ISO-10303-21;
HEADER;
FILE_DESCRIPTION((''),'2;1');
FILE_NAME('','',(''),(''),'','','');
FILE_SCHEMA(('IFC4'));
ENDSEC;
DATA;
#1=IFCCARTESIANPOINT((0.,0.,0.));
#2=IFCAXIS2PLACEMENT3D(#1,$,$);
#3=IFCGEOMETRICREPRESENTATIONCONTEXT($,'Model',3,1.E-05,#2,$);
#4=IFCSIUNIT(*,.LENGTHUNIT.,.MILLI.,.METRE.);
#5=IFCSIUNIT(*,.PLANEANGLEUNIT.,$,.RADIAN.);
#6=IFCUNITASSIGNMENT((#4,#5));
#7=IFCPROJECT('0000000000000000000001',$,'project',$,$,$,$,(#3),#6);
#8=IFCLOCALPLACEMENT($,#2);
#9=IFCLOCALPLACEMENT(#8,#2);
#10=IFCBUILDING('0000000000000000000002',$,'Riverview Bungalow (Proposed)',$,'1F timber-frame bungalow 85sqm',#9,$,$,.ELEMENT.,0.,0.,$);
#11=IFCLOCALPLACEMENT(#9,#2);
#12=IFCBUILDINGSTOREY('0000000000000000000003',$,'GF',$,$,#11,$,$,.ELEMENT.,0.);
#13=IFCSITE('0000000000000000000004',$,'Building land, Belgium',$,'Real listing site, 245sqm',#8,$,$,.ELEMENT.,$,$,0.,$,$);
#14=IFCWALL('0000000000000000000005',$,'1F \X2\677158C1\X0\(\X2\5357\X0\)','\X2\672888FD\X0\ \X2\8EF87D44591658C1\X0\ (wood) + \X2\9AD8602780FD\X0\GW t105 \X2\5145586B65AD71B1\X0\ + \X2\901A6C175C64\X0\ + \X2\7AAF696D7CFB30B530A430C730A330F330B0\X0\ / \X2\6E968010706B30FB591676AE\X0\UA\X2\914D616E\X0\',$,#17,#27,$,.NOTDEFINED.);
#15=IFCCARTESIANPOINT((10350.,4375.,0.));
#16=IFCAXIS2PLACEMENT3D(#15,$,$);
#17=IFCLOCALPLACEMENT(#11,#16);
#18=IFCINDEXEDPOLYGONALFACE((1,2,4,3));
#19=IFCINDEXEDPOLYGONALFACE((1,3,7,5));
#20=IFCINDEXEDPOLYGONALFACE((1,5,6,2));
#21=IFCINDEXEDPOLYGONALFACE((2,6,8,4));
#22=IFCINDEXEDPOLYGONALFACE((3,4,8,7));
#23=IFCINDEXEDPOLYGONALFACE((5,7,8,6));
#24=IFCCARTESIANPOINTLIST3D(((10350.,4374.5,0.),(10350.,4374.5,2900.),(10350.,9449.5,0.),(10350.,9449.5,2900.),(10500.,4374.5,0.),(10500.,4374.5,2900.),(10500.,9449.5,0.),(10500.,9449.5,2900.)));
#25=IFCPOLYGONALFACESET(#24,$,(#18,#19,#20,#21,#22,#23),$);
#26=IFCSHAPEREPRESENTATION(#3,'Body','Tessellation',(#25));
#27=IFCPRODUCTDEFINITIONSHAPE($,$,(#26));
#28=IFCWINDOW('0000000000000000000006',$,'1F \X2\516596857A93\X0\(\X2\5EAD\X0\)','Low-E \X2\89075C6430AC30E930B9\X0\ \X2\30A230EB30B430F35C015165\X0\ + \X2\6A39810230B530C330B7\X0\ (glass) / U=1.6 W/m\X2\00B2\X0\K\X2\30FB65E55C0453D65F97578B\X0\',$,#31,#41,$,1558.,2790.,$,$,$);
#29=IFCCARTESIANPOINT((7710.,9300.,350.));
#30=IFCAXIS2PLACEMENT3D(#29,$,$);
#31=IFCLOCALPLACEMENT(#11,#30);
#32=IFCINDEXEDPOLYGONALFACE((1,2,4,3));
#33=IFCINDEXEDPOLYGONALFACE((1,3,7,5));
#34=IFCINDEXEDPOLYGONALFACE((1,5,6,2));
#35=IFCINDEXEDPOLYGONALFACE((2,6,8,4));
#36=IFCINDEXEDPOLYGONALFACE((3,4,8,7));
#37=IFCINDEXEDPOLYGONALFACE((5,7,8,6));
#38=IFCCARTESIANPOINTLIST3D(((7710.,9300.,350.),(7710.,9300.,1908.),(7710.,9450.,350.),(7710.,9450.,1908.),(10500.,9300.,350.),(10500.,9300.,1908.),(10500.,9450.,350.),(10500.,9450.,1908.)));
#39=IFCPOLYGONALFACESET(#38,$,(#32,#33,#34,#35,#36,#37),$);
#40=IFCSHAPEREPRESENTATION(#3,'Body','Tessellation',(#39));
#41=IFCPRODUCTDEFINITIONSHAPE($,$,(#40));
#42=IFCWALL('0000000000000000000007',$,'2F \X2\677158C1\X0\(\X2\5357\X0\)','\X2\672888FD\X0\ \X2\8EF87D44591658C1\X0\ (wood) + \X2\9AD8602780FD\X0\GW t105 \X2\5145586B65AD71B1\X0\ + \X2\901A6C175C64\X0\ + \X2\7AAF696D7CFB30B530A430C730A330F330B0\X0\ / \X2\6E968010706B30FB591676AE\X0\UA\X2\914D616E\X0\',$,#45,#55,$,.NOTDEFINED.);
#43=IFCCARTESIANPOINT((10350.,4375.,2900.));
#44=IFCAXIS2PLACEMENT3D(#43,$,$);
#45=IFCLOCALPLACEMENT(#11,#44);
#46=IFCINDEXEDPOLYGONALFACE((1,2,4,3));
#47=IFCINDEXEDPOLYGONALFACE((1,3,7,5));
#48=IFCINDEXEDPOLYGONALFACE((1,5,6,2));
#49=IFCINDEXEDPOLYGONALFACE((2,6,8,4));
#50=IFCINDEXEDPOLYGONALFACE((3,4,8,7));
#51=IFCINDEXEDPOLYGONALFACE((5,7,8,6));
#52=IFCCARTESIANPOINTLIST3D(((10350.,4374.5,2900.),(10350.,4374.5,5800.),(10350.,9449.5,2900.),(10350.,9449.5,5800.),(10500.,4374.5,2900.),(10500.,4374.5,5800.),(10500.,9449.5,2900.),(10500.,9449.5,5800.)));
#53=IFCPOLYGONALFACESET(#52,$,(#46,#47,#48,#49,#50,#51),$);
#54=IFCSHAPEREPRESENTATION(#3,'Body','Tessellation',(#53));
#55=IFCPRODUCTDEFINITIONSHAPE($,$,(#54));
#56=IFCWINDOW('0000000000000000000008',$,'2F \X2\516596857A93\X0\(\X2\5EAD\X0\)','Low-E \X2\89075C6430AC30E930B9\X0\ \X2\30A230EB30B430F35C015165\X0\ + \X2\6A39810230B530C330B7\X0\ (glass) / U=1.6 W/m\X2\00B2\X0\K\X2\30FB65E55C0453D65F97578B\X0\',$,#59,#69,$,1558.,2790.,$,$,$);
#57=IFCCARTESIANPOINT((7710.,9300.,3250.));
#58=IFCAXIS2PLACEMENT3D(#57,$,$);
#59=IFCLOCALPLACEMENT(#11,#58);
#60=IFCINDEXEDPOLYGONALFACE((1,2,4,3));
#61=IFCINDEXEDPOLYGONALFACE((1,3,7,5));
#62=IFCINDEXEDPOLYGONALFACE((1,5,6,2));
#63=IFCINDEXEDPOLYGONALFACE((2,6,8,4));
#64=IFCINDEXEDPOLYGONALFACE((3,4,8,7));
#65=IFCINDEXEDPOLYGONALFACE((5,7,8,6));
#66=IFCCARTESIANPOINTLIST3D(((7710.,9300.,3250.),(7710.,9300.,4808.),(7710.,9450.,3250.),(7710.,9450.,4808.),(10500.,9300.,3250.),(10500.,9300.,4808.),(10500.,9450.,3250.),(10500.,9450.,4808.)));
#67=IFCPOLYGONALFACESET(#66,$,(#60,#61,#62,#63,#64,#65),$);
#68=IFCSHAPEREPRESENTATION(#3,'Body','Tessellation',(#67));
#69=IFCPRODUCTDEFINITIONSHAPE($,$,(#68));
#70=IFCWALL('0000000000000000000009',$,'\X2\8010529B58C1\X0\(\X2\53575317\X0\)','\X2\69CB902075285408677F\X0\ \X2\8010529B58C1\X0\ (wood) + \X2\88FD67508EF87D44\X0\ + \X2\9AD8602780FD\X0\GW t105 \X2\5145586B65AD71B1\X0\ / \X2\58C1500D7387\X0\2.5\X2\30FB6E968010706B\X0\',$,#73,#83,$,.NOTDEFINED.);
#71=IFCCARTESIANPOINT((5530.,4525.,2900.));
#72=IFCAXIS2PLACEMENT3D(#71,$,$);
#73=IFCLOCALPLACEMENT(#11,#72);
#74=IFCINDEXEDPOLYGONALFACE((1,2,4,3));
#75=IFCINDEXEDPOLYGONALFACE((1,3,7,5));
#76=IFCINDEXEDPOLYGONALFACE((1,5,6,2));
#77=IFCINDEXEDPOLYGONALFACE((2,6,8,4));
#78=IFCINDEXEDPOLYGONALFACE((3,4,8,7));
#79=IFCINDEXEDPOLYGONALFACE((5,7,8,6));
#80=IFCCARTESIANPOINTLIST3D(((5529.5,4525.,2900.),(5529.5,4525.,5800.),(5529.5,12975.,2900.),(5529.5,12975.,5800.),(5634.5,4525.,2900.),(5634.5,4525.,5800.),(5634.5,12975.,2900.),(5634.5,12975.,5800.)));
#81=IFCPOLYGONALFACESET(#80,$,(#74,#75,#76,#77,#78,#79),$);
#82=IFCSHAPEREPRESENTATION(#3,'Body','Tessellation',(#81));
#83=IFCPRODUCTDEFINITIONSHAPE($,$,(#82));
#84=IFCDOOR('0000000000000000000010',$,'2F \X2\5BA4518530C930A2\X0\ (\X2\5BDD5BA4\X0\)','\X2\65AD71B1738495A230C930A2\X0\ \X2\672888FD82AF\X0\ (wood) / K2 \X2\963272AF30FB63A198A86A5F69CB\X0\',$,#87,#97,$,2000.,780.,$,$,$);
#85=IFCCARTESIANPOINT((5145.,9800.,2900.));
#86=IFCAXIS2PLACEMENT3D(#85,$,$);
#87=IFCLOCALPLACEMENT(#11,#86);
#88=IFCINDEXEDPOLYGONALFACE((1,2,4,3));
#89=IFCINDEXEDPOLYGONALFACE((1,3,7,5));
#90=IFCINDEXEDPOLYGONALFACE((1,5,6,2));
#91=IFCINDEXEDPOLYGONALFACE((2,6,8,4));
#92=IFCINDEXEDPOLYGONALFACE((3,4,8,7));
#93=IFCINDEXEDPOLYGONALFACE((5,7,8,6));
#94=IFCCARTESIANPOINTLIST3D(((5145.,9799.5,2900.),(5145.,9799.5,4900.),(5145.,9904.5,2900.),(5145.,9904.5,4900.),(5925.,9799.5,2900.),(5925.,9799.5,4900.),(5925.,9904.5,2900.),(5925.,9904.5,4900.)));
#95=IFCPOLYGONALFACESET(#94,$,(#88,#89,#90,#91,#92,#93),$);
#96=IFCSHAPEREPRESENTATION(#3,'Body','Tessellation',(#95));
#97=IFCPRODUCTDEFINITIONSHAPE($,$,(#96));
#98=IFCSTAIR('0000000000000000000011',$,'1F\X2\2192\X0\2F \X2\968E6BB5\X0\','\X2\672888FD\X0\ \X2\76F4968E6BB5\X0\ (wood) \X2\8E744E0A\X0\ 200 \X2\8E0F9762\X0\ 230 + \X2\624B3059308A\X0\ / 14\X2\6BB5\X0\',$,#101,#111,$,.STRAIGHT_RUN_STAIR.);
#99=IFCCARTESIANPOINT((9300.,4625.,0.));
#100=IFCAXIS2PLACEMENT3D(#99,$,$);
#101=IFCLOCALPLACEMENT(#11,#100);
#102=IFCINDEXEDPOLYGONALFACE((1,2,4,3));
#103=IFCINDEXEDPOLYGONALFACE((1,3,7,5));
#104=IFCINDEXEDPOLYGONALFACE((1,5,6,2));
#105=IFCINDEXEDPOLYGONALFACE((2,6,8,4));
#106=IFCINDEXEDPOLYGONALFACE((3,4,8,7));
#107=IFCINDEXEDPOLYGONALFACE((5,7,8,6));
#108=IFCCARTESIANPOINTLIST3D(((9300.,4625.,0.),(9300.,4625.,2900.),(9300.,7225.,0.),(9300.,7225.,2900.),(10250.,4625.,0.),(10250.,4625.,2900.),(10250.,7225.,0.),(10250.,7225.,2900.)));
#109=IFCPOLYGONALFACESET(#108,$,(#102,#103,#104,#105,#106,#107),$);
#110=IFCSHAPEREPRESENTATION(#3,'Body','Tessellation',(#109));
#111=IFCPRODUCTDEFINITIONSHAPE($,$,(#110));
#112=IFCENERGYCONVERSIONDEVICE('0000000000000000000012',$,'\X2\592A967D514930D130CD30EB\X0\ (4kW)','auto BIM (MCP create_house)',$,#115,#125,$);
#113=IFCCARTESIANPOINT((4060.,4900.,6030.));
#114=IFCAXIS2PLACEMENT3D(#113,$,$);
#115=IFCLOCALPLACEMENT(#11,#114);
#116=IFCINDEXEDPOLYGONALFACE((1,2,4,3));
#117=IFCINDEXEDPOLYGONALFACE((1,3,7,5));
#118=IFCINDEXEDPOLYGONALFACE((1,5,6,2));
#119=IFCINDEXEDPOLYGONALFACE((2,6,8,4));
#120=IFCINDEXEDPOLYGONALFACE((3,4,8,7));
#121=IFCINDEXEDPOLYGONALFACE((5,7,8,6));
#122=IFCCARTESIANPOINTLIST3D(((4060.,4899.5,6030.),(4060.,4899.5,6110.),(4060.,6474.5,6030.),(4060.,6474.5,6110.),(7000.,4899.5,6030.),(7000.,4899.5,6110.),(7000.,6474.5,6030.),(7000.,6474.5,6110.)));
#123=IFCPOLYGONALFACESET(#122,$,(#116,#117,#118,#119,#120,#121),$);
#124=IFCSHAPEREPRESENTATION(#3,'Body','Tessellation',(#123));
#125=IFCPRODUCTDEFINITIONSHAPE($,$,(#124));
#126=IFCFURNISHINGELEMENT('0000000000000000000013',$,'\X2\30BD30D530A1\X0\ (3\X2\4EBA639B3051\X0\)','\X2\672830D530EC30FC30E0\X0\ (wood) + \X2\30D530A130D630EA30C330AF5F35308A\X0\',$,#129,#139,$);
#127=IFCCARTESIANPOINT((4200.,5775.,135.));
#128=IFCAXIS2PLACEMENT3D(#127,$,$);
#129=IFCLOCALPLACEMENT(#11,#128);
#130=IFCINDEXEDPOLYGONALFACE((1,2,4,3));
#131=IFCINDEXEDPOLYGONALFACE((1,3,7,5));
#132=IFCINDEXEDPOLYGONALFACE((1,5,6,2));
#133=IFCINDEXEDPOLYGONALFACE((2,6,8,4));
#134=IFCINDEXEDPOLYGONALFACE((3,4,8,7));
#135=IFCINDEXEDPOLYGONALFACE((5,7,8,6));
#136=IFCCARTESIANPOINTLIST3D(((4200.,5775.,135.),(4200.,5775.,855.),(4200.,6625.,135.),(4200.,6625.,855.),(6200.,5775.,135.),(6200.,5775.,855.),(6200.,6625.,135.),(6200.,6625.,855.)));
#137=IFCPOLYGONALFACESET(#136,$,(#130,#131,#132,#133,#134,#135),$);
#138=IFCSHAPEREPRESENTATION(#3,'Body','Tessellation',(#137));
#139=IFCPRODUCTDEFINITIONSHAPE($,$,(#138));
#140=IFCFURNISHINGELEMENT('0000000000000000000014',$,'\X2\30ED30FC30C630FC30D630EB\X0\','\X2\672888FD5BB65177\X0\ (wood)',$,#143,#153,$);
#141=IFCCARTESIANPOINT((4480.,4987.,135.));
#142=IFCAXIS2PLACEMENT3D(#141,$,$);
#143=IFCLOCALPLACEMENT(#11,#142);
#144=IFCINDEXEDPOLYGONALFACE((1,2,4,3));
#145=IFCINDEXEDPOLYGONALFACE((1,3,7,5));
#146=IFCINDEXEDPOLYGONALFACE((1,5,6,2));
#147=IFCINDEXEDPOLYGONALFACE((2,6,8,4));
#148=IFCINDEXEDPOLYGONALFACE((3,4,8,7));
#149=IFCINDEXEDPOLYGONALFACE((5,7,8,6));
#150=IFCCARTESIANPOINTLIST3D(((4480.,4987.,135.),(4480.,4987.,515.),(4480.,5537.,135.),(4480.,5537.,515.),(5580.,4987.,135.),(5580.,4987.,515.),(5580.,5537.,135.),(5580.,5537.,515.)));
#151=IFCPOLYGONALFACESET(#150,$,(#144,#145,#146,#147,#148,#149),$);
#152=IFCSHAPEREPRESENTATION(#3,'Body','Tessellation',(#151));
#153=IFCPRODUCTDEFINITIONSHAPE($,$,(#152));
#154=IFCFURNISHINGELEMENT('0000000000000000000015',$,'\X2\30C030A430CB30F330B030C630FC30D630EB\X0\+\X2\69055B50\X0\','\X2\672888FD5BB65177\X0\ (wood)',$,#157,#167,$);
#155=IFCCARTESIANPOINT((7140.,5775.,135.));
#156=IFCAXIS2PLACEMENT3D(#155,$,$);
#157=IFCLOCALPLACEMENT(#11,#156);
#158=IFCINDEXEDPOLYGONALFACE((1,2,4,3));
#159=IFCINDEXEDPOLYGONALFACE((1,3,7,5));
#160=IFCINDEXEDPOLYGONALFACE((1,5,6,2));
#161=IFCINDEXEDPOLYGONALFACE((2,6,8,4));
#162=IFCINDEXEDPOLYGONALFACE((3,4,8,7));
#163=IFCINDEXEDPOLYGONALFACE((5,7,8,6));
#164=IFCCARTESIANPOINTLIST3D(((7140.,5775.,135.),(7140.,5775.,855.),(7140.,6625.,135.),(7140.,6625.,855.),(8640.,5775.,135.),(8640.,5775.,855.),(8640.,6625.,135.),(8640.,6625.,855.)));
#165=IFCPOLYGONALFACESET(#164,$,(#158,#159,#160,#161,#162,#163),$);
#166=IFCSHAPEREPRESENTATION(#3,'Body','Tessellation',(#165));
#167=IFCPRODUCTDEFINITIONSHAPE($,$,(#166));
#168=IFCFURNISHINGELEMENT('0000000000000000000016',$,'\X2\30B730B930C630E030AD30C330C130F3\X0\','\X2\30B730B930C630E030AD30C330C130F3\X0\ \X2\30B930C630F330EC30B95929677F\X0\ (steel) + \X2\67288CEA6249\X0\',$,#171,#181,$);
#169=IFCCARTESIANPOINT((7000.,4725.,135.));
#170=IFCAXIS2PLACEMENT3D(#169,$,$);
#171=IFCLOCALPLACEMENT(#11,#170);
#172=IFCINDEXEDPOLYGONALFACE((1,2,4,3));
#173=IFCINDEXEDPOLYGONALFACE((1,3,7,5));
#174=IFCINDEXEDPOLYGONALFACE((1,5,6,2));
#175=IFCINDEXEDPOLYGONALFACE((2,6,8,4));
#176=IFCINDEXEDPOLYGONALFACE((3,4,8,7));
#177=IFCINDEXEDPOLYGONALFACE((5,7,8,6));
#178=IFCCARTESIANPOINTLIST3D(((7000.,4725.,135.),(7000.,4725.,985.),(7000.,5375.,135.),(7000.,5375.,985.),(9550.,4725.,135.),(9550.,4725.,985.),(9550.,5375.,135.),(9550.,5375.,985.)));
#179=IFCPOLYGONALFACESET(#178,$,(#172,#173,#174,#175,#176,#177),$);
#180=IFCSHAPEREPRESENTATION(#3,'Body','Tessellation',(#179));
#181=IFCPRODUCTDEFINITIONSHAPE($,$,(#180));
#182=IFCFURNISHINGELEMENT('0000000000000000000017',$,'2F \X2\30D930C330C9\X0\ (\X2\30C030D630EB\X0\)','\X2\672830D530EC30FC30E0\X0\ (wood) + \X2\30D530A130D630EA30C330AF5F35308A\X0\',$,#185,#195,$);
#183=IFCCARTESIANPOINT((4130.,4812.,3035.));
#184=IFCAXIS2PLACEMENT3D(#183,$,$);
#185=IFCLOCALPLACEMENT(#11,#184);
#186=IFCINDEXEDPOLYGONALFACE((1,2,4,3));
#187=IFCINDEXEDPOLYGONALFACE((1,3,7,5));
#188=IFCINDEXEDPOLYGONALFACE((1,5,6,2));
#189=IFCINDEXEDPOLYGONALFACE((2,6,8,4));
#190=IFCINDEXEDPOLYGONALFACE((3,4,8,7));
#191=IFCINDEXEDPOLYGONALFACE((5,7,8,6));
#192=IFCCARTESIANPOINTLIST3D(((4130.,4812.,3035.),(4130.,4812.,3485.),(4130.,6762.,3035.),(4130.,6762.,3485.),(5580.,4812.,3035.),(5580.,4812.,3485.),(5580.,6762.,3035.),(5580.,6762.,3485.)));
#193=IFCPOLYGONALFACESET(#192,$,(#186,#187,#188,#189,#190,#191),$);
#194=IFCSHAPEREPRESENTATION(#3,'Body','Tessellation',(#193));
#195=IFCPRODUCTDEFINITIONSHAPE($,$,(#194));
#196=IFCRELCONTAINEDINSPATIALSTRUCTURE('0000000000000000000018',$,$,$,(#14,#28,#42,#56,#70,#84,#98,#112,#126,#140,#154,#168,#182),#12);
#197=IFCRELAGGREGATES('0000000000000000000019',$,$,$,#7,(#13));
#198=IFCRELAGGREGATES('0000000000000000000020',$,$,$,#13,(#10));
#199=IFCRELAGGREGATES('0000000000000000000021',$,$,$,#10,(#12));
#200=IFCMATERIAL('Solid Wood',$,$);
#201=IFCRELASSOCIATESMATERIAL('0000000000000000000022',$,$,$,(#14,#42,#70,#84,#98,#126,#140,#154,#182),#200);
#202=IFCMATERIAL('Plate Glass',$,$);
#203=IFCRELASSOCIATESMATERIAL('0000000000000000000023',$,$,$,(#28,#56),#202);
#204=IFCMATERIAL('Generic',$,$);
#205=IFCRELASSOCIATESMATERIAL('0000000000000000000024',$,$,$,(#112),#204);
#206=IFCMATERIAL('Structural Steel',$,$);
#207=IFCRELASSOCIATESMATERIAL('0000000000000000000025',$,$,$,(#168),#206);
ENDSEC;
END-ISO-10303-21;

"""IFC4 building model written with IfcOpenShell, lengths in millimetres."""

from ifc_helpers import new_model, si_unit, frame, frame_2d, origin, place, context, project, spatial, rectangle, extrude, material, element, fill, save


model = new_model("IFC4")

# Units and contexts
model_context = context("Model", 3, precision=1e-05, world=origin())
ifc_project = project(units=[si_unit("LENGTHUNIT", "METRE", prefix="MILLI"), si_unit("PLANEANGLEUNIT", "RADIAN")], contexts=[model_context])

# Site, building, storey
site_placement = place(None, origin())
site = spatial("IfcSite", under=ifc_project, at=site_placement, Name="Building land, Belgium", ObjectType="Real listing site, 245sqm", CompositionType="ELEMENT", RefElevation=0.0)
building_placement = place(site_placement, origin())
building = spatial("IfcBuilding", under=site, at=building_placement, Name="Riverview Bungalow (Proposed)", ObjectType="1F timber-frame bungalow 85sqm", CompositionType="ELEMENT", ElevationOfRefHeight=0.0, ElevationOfTerrain=0.0)
storey_placement = place(building_placement, origin())
storey = spatial("IfcBuildingStorey", under=building, at=storey_placement, Name="GF", CompositionType="ELEMENT", Elevation=0.0)

# Wall, opening, window
ifc_material_1 = material(Name="Solid Wood")
wall_1_placement = place(storey_placement, frame((10350.0, 4375.0, 0.0)))
wall_1 = element("IfcWall", 1, at=wall_1_placement, inside=storey, material=ifc_material_1, Name="1F 東壁(南)", Description="木製 軸組外壁 (wood) + 高性能GW t105 充填断熱 + 通気層 + 窯業系サイディング / 準耐火・外皮UA配慮", PredefinedType="NOTDEFINED", context=model_context, shape_type="SweptSolid", body=[
    extrude(rectangle(XDim=150.0, YDim=5075.0, at=frame_2d((75.0, 2537.0))), frame((10350.0, 4375.0, 0.0)), (0.0, 0.0, 1.0), 2900.0),
])
opening_1_placement = place(storey_placement, frame((7710.0, 9300.0, 350.0)))
opening_1 = element("IfcOpeningElement", 2, at=opening_1_placement, cuts=wall_1, PredefinedType="NOTDEFINED", context=model_context, shape_type="SweptSolid", body=[
    extrude(rectangle(XDim=2790.0, YDim=150.0, at=frame_2d((1395.0, 75.0))), frame((7710.0, 9300.0, 350.0)), (0.0, 0.0, 1.0), 1558.0),
])
ifc_material_2 = material(Name="Plate Glass")
window_1_placement = place(storey_placement, frame((7710.0, 9300.0, 350.0)))
window_1 = element("IfcWindow", 3, at=window_1_placement, inside=storey, material=ifc_material_2, Name="1F 入隅窓(庭)", Description="Low-E 複層ガラス アルゴン封入 + 樹脂サッシ (glass) / U=1.6 W/m²K・日射取得型", OverallHeight=1558.0, OverallWidth=2790.0, context=model_context, shape_type="SweptSolid", body=[
    extrude(rectangle(XDim=2790.0, YDim=150.0, at=frame_2d((1395.0, 75.0))), frame((7710.0, 9300.0, 350.0)), (0.0, 0.0, 1.0), 1558.0),
])
fill(opening_1, window_1)

# Wall, opening, window
wall_2_placement = place(storey_placement, frame((10350.0, 4375.0, 2900.0)))
wall_2 = element("IfcWall", 4, at=wall_2_placement, inside=storey, material=ifc_material_1, Name="2F 東壁(南)", Description="木製 軸組外壁 (wood) + 高性能GW t105 充填断熱 + 通気層 + 窯業系サイディング / 準耐火・外皮UA配慮", PredefinedType="NOTDEFINED", context=model_context, shape_type="SweptSolid", body=[
    extrude(rectangle(XDim=150.0, YDim=5075.0, at=frame_2d((75.0, 2537.0))), frame((10350.0, 4375.0, 2900.0)), (0.0, 0.0, 1.0), 2900.0),
])
opening_2_placement = place(storey_placement, frame((7710.0, 9300.0, 3250.0)))
opening_2 = element("IfcOpeningElement", 5, at=opening_2_placement, cuts=wall_2, PredefinedType="NOTDEFINED", context=model_context, shape_type="SweptSolid", body=[
    extrude(rectangle(XDim=2790.0, YDim=150.0, at=frame_2d((1395.0, 75.0))), frame((7710.0, 9300.0, 3250.0)), (0.0, 0.0, 1.0), 1558.0),
])
window_2_placement = place(storey_placement, frame((7710.0, 9300.0, 3250.0)))
window_2 = element("IfcWindow", 6, at=window_2_placement, inside=storey, material=ifc_material_2, Name="2F 入隅窓(庭)", Description="Low-E 複層ガラス アルゴン封入 + 樹脂サッシ (glass) / U=1.6 W/m²K・日射取得型", OverallHeight=1558.0, OverallWidth=2790.0, context=model_context, shape_type="SweptSolid", body=[
    extrude(rectangle(XDim=2790.0, YDim=150.0, at=frame_2d((1395.0, 75.0))), frame((7710.0, 9300.0, 3250.0)), (0.0, 0.0, 1.0), 1558.0),
])
fill(opening_2, window_2)

# Wall, opening, door
wall_3_placement = place(storey_placement, frame((5530.0, 4525.0, 2900.0)))
wall_3 = element("IfcWall", 7, at=wall_3_placement, inside=storey, material=ifc_material_1, Name="耐力壁(南北)", Description="構造用合板 耐力壁 (wood) + 製材軸組 + 高性能GW t105 充填断熱 / 壁倍率2.5・準耐火", PredefinedType="NOTDEFINED", context=model_context, shape_type="SweptSolid", body=[
    extrude(rectangle(XDim=105.0, YDim=8450.0, at=frame_2d((52.0, 4225.0))), frame((5530.0, 4525.0, 2900.0)), (0.0, 0.0, 1.0), 2900.0),
])
opening_3_placement = place(storey_placement, frame((5145.0, 9800.0, 2900.0)))
opening_3 = element("IfcOpeningElement", 8, at=opening_3_placement, cuts=wall_3, PredefinedType="NOTDEFINED", context=model_context, shape_type="SweptSolid", body=[
    extrude(rectangle(XDim=780.0, YDim=105.0, at=frame_2d((390.0, 52.0))), frame((5145.0, 9800.0, 2900.0)), (0.0, 0.0, 1.0), 2000.0),
])
door_1_placement = place(storey_placement, frame((5145.0, 9800.0, 2900.0)))
door_1 = element("IfcDoor", 9, at=door_1_placement, inside=storey, material=ifc_material_1, Name="2F 室内ドア (寝室)", Description="断熱玄関ドア 木製芯 (wood) / K2 防犯・採風機構", OverallHeight=2000.0, OverallWidth=780.0, context=model_context, shape_type="SweptSolid", body=[
    extrude(rectangle(XDim=780.0, YDim=105.0, at=frame_2d((390.0, 52.0))), frame((5145.0, 9800.0, 2900.0)), (0.0, 0.0, 1.0), 2000.0),
])
fill(opening_3, door_1)

# Stair
stair_placement = place(storey_placement, frame((9300.0, 4625.0, 0.0)))
element("IfcStair", 10, at=stair_placement, inside=storey, material=ifc_material_1, Name="1F→2F 階段", Description="木製 直階段 (wood) 蹴上 200 踏面 230 + 手すり / 14段", PredefinedType="STRAIGHT_RUN_STAIR", context=model_context, shape_type="SweptSolid", body=[
    extrude(rectangle(XDim=950.0, YDim=2600.0, at=frame_2d((475.0, 1300.0))), frame((9300.0, 4625.0, 0.0)), (0.0, 0.0, 1.0), 2900.0),
])

# Energy conversion device
ifc_material_3 = material(Name="Generic")
energy_conversion_device_placement = place(storey_placement, frame((4060.0, 4900.0, 6030.0)))
element("IfcEnergyConversionDevice", 11, at=energy_conversion_device_placement, inside=storey, material=ifc_material_3, Name="太陽光パネル (4kW)", Description="auto BIM (MCP create_house)", context=model_context, shape_type="SweptSolid", body=[
    extrude(rectangle(XDim=2940.0, YDim=1575.0, at=frame_2d((1470.0, 787.0))), frame((4060.0, 4900.0, 6030.0)), (0.0, 0.0, 1.0), 80.0),
])

# Furnishing elements
furnishing_1_placement = place(storey_placement, frame((4200.0, 5775.0, 135.0)))
element("IfcFurnishingElement", 12, at=furnishing_1_placement, inside=storey, material=ifc_material_1, Name="ソファ (3人掛け)", Description="木フレーム (wood) + ファブリック張り", context=model_context, shape_type="SweptSolid", body=[
    extrude(rectangle(XDim=2000.0, YDim=850.0, at=frame_2d((1000.0, 425.0))), frame((4200.0, 5775.0, 135.0)), (0.0, 0.0, 1.0), 720.0),
])
furnishing_2_placement = place(storey_placement, frame((4480.0, 4987.0, 135.0)))
element("IfcFurnishingElement", 13, at=furnishing_2_placement, inside=storey, material=ifc_material_1, Name="ローテーブル", Description="木製家具 (wood)", context=model_context, shape_type="SweptSolid", body=[
    extrude(rectangle(XDim=1100.0, YDim=550.0, at=frame_2d((550.0, 275.0))), frame((4480.0, 4987.0, 135.0)), (0.0, 0.0, 1.0), 380.0),
])
furnishing_3_placement = place(storey_placement, frame((7140.0, 5775.0, 135.0)))
element("IfcFurnishingElement", 14, at=furnishing_3_placement, inside=storey, material=ifc_material_1, Name="ダイニングテーブル+椅子", Description="木製家具 (wood)", context=model_context, shape_type="SweptSolid", body=[
    extrude(rectangle(XDim=1500.0, YDim=850.0, at=frame_2d((750.0, 425.0))), frame((7140.0, 5775.0, 135.0)), (0.0, 0.0, 1.0), 720.0),
])
ifc_material_4 = material(Name="Structural Steel")
furnishing_4_placement = place(storey_placement, frame((7000.0, 4725.0, 135.0)))
element("IfcFurnishingElement", 15, at=furnishing_4_placement, inside=storey, material=ifc_material_4, Name="システムキッチン", Description="システムキッチン ステンレス天板 (steel) + 木質扉", context=model_context, shape_type="SweptSolid", body=[
    extrude(rectangle(XDim=2550.0, YDim=650.0, at=frame_2d((1275.0, 325.0))), frame((7000.0, 4725.0, 135.0)), (0.0, 0.0, 1.0), 850.0),
])
furnishing_5_placement = place(storey_placement, frame((4130.0, 4812.0, 3035.0)))
element("IfcFurnishingElement", 16, at=furnishing_5_placement, inside=storey, material=ifc_material_1, Name="2F ベッド (ダブル)", Description="木フレーム (wood) + ファブリック張り", context=model_context, shape_type="SweptSolid", body=[
    extrude(rectangle(XDim=1450.0, YDim=1950.0, at=frame_2d((725.0, 975.0))), frame((4130.0, 4812.0, 3035.0)), (0.0, 0.0, 1.0), 450.0),
])

save(model, "model.ifc")
